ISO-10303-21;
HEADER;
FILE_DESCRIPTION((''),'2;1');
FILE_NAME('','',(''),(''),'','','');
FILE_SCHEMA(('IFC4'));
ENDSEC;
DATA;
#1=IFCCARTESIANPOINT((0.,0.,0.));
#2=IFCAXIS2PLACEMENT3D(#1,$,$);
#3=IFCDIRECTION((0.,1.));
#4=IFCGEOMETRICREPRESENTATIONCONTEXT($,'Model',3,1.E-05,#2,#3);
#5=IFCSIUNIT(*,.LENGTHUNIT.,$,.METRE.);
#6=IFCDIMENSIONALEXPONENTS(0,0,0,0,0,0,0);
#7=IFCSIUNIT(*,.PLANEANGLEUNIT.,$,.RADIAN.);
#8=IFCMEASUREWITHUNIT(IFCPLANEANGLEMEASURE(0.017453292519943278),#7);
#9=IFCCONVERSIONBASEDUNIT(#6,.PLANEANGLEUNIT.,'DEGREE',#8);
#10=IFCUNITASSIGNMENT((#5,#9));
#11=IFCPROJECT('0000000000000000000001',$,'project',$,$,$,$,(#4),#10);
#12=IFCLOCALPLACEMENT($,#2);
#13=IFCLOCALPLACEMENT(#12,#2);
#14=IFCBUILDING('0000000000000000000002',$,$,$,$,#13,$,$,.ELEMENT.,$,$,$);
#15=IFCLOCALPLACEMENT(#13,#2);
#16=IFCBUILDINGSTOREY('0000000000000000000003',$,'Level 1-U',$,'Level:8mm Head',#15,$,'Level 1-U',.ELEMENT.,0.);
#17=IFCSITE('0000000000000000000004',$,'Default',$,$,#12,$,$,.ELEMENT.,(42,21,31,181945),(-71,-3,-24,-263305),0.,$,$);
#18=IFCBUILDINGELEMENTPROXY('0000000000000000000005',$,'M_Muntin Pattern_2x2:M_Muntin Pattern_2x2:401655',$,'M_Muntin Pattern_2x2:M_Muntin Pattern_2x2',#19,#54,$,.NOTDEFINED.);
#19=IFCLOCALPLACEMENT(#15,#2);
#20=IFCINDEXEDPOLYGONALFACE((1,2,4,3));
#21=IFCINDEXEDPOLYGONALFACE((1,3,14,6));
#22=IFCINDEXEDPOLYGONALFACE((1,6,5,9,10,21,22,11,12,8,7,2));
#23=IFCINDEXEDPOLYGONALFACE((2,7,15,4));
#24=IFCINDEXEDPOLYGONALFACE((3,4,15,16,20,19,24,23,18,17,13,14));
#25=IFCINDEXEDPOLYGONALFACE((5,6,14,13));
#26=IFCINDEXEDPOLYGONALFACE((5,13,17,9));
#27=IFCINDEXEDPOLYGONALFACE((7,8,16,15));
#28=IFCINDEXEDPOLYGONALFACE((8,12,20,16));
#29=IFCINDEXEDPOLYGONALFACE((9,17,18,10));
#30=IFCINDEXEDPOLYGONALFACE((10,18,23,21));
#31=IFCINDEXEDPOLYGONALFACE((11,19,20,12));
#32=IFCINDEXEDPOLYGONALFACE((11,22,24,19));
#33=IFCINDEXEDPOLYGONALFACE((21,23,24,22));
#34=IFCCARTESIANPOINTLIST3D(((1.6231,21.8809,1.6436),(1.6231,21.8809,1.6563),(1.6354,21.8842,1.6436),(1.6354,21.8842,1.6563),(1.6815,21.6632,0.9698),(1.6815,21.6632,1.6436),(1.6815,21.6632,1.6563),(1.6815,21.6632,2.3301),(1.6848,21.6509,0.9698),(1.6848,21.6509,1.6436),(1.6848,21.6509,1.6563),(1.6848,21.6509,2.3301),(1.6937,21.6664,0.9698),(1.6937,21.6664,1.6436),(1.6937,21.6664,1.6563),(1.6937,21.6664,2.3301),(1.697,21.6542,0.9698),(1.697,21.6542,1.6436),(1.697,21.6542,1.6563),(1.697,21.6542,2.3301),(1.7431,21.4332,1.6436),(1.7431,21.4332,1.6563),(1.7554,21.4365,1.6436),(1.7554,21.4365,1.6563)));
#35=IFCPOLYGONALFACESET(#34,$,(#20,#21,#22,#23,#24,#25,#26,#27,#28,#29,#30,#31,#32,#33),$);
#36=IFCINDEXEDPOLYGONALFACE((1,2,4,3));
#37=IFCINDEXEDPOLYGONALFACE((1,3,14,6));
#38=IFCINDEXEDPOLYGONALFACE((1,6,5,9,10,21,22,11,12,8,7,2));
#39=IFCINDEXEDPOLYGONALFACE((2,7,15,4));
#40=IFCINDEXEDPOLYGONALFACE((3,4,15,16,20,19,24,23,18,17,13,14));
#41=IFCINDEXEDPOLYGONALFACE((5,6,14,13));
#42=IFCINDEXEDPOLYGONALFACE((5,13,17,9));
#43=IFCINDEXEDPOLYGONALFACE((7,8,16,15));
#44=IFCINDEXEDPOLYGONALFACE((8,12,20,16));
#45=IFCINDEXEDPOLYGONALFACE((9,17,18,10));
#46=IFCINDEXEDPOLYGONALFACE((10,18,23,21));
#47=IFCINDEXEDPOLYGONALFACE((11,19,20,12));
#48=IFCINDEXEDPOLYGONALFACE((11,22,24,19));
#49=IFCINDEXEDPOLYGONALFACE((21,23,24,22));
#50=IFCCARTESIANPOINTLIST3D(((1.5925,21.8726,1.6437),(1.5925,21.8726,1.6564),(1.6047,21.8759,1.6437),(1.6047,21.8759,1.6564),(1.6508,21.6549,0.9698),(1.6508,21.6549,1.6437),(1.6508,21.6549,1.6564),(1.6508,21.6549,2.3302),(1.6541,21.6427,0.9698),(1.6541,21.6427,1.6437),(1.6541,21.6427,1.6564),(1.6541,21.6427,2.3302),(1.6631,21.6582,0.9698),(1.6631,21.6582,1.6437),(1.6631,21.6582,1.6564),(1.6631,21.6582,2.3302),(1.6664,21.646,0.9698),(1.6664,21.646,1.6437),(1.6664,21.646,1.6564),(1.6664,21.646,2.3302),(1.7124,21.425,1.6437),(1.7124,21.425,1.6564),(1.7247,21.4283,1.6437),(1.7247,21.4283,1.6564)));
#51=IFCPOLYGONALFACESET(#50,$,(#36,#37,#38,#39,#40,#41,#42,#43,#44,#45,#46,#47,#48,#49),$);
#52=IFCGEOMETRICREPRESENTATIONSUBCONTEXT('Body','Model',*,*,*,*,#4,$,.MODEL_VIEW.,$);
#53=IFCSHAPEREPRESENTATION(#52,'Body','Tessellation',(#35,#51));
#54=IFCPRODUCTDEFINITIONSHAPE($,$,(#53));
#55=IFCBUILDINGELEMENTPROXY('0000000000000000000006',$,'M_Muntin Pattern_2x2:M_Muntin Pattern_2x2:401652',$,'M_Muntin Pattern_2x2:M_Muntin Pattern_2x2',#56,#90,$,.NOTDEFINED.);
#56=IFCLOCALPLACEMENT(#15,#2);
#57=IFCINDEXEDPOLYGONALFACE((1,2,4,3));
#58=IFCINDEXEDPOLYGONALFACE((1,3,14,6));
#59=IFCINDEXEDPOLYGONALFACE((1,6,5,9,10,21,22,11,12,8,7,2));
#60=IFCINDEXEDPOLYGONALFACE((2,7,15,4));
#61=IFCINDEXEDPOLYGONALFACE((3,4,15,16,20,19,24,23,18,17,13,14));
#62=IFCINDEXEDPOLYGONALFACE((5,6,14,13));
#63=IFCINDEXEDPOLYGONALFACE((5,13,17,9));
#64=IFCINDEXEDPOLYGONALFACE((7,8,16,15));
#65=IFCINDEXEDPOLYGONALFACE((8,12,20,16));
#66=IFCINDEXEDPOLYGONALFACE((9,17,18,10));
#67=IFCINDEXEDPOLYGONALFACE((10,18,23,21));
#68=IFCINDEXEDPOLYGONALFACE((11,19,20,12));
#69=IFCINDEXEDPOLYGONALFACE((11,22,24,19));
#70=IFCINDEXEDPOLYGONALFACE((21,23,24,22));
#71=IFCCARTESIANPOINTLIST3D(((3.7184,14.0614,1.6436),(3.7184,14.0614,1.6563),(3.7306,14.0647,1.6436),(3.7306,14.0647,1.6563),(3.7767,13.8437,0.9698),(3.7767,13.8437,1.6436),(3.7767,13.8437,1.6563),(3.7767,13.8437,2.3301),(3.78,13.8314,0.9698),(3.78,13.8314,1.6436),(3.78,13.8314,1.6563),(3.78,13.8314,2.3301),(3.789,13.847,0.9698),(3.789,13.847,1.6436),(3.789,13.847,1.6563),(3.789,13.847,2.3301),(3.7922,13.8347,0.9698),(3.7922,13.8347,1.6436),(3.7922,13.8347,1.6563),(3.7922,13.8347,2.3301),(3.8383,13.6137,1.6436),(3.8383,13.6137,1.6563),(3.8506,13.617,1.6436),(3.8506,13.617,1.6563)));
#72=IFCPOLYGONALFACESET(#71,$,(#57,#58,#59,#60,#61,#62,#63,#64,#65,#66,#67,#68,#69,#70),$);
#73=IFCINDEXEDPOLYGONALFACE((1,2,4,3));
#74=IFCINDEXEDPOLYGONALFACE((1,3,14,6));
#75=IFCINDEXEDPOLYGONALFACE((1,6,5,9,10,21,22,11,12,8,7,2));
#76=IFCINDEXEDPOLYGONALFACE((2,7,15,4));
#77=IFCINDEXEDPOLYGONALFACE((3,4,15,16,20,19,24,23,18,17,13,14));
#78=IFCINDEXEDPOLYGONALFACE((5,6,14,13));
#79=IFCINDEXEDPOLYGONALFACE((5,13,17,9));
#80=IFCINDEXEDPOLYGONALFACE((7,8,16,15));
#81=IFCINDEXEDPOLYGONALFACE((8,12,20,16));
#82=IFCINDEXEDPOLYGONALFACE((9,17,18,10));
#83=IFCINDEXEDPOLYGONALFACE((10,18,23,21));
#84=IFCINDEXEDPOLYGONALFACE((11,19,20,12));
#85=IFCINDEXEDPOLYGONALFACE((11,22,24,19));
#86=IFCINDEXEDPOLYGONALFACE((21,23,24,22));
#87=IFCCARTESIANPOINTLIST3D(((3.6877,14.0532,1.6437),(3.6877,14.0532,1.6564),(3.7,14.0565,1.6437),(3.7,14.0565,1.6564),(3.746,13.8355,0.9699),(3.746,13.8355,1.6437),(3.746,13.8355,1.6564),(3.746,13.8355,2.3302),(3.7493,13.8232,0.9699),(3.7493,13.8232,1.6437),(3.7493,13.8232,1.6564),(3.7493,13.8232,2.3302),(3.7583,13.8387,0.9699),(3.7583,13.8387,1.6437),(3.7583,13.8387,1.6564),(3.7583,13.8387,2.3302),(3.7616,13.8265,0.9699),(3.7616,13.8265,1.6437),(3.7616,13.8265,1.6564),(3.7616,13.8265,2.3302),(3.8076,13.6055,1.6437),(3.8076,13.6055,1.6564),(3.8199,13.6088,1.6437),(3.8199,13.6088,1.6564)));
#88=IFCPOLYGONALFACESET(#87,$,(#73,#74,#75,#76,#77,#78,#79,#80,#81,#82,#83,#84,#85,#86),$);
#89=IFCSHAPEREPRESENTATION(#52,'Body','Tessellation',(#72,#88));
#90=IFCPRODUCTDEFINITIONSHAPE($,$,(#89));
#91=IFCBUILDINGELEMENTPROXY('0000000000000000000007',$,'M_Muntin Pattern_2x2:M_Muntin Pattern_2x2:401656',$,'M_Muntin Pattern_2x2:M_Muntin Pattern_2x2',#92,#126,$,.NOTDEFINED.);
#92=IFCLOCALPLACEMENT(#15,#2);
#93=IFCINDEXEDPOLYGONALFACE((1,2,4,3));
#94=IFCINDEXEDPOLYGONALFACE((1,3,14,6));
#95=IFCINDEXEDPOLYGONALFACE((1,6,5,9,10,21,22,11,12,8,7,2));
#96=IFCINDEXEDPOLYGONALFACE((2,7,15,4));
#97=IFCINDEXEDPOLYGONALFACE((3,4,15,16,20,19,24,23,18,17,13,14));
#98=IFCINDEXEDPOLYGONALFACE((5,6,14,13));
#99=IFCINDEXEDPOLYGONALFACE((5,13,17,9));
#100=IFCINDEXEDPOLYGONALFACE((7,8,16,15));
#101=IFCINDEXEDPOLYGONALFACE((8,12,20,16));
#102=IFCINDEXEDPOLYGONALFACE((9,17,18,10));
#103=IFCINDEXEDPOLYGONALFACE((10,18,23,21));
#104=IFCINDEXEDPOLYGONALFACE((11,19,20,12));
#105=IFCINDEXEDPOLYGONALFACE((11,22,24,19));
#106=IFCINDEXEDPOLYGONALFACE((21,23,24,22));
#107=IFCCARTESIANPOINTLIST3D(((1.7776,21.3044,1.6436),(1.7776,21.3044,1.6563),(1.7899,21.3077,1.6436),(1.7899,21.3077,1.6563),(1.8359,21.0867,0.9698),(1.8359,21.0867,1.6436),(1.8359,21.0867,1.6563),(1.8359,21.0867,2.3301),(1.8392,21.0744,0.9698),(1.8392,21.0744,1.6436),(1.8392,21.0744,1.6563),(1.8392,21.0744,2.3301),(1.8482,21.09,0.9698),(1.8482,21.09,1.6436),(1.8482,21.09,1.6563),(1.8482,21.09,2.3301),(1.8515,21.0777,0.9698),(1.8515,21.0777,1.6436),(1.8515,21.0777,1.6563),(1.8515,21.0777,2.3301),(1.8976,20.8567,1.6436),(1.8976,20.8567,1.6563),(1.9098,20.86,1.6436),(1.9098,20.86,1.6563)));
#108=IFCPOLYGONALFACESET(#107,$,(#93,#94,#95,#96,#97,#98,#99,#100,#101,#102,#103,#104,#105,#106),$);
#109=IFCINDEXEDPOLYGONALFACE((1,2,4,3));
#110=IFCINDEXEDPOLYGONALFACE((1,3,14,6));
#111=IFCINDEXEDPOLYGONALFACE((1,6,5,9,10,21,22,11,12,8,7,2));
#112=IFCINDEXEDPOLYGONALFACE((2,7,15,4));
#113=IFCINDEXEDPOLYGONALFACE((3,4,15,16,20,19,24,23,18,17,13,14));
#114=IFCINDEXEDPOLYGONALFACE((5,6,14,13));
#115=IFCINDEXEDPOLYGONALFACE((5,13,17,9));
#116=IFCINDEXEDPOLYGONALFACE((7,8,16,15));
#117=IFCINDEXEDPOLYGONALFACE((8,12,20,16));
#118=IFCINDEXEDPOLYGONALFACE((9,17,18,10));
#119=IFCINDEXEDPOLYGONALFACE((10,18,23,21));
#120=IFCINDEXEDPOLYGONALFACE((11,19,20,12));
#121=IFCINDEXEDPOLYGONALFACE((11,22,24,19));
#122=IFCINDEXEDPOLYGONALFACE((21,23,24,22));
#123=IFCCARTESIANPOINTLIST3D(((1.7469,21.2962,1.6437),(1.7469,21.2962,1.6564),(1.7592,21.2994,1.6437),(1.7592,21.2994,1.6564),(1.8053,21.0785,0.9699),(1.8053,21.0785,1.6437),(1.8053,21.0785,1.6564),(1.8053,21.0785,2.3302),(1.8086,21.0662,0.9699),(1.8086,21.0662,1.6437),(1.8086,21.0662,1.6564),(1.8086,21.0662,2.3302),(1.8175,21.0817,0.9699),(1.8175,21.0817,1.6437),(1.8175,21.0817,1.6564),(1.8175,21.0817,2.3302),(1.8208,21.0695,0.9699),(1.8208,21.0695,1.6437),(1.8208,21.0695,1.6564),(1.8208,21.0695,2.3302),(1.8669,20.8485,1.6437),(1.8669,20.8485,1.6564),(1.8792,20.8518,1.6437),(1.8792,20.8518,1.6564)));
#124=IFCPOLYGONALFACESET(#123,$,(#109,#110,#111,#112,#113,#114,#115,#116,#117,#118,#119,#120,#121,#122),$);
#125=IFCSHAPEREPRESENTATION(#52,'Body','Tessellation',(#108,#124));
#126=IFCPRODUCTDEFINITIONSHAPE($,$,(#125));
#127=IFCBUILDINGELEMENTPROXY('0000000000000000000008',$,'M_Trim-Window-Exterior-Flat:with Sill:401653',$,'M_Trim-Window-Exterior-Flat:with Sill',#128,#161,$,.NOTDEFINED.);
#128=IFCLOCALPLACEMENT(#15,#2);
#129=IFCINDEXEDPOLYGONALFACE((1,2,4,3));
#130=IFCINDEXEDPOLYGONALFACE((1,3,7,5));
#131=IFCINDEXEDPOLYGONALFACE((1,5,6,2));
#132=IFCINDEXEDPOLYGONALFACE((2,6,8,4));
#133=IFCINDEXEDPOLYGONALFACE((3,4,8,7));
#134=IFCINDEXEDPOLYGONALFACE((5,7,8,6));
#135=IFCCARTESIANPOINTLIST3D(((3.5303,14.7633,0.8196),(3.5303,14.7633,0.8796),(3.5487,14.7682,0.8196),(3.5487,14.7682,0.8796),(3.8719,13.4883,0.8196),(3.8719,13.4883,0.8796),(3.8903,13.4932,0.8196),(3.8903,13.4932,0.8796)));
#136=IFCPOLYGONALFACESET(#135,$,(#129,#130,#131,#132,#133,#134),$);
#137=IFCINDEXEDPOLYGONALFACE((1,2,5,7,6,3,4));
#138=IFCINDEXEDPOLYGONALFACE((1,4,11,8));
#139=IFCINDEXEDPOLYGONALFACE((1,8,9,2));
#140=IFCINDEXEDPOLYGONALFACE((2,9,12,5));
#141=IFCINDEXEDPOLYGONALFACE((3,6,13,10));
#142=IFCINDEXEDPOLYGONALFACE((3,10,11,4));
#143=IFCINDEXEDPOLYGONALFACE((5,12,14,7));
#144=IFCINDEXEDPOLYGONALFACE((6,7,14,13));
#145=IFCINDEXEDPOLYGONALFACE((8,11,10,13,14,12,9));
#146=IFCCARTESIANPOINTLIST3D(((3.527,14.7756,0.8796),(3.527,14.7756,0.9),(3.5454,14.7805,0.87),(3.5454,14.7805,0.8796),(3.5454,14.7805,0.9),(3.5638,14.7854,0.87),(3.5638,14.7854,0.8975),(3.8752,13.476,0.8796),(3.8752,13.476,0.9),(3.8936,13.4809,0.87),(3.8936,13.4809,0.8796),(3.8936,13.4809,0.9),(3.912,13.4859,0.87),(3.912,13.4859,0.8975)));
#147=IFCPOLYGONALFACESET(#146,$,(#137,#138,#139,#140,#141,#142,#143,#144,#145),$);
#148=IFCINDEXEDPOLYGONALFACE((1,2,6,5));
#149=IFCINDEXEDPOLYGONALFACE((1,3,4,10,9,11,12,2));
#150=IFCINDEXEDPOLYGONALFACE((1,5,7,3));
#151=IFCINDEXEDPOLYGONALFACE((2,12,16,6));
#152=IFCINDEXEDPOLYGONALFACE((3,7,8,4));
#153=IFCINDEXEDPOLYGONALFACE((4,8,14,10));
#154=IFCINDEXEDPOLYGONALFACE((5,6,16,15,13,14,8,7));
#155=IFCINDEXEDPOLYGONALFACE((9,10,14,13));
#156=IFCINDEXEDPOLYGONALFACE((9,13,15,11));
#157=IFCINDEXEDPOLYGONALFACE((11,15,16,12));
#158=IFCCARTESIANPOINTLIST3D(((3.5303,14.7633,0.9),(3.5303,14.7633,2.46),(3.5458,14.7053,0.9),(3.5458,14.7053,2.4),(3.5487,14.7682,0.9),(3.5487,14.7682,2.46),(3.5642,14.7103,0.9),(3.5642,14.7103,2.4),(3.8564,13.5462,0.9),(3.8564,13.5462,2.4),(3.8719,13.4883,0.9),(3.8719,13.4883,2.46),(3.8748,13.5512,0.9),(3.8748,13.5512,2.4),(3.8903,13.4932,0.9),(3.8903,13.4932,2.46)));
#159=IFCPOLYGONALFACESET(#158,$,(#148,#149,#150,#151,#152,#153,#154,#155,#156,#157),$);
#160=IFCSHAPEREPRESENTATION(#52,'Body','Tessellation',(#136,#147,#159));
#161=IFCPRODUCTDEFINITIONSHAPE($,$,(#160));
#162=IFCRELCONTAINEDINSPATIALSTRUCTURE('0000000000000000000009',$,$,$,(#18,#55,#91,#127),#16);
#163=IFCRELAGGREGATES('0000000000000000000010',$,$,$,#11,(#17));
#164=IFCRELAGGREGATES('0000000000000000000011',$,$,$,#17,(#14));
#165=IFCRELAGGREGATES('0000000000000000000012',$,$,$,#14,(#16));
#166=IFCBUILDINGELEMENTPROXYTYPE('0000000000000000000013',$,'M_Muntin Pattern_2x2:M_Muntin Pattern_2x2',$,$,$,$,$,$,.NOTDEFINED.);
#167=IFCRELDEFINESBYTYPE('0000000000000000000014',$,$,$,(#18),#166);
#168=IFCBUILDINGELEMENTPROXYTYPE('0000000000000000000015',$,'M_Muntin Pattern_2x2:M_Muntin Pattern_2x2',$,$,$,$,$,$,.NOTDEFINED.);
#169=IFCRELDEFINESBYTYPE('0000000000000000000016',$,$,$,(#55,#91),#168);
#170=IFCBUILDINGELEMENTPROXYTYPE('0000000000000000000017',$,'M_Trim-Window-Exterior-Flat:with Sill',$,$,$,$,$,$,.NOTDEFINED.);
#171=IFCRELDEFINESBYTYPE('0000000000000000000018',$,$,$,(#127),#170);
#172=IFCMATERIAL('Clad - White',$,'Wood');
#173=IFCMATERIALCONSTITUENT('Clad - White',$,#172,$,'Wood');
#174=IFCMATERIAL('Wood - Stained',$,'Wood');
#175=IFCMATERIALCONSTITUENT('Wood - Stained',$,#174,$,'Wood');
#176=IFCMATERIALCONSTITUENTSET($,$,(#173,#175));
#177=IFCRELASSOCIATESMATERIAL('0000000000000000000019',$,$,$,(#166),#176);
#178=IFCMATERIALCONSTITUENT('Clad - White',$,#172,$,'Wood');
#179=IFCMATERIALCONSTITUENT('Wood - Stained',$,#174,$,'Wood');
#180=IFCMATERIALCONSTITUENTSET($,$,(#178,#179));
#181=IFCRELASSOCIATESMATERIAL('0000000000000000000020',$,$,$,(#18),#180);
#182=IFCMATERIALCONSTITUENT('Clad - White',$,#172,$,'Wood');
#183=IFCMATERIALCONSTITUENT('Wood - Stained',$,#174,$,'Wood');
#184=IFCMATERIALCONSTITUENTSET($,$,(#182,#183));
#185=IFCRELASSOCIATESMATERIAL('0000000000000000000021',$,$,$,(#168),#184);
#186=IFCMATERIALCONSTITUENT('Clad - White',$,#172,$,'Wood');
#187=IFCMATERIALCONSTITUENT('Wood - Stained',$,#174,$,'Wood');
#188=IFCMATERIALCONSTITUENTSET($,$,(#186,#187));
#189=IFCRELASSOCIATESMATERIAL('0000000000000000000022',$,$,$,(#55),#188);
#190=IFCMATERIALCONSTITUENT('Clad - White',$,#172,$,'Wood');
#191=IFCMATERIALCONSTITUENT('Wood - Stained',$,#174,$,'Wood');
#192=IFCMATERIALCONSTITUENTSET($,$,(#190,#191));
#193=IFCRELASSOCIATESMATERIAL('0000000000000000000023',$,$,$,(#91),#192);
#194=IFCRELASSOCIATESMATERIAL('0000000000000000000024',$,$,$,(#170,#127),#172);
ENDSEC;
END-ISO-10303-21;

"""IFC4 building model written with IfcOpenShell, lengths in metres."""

from ifc_helpers import new_model, entity, si_unit, converted_unit, direction, frame, origin, place, context, subcontext, project, spatial, indexed_curve, outline, extrude, source, transform, mapped, material, constituent, constituent_set, type_object, type_shapes, element, save


model = new_model("IFC4")

# Units and contexts
model_context = context("Model", 3, precision=1e-05, world=origin(), true_north=direction((0.0, 1.0)))
body_context = subcontext(model_context, "Body", "Model", "MODEL_VIEW")
ifc_project = project(units=[si_unit("LENGTHUNIT", "METRE"), converted_unit("PLANEANGLEUNIT", "DEGREE", entity("IfcPlaneAngleMeasure", 0.017453292519943278), si_unit("PLANEANGLEUNIT", "RADIAN"), dimensions=[0, 0, 0, 0, 0, 0, 0])], contexts=[model_context])

# Site, building, storey
site_placement = place(None, origin())
site = spatial("IfcSite", under=ifc_project, at=site_placement, Name="Default", CompositionType="ELEMENT", RefLatitude=(42, 21, 31, 181945), RefLongitude=(-71, -3, -24, -263305), RefElevation=0.0)
building_placement = place(site_placement, origin())
building = spatial("IfcBuilding", under=site, at=building_placement, CompositionType="ELEMENT")
storey_placement = place(building_placement, origin())
storey = spatial("IfcBuildingStorey", under=building, at=storey_placement, Name="Level 1-U", ObjectType="Level:8mm Head", LongName="Level 1-U", CompositionType="ELEMENT", Elevation=0.0)

# Building element proxies
ifc_material_1 = material(Name="Clad - White", Category="Wood")
ifc_material_2 = material(Name="Wood - Stained", Category="Wood")
ifc_constituent_1 = constituent(ifc_material_1, Name="Clad - White", Category="Wood")
ifc_constituent_2 = constituent(ifc_material_2, Name="Wood - Stained", Category="Wood")
ifc_constituent_set_1 = constituent_set(constituents=[ifc_constituent_1, ifc_constituent_2])
building_element_proxy_type_1 = type_object("IfcBuildingElementProxyType", Name="M_Muntin Pattern_2x2:M_Muntin Pattern_2x2", PredefinedType="NOTDEFINED", material=ifc_constituent_set_1)
shared_shape_1 = source(origin(), body_context, "Body", "SweptSolid", [
    extrude(outline(indexed_curve([(0.0064, -0.0064), (0.6801, -0.0064), (0.6801, 0.0063), (0.0064, 0.0063), (0.0064, 0.2317), (-0.0063, 0.2317), (-0.0063, 0.0063), (-0.6802, 0.0063), (-0.6802, -0.0064), (-0.0063, -0.0064), (-0.0063, -0.2317), (0.0064, -0.2317), (0.0064, -0.0064)], self_intersect=False)), frame((0.0, 0.0095, 0.6801), z_axis=(0.0, 1.0, 0.0), x_axis=(0.0, 0.0, 1.0)), (0.0, 0.0, 1.0), 0.0127),
    extrude(outline(indexed_curve([(0.0064, -0.0064), (0.6802, -0.0064), (0.6802, 0.0063), (0.0064, 0.0063), (0.0064, 0.2317), (-0.0063, 0.2317), (-0.0063, 0.0063), (-0.6802, 0.0063), (-0.6802, -0.0064), (-0.0063, -0.0064), (-0.0063, -0.2317), (0.0064, -0.2317), (0.0064, -0.0064)], self_intersect=False)), frame((0.0, -0.0222, 0.6802), z_axis=(0.0, 1.0, 0.0), x_axis=(0.0, 0.0, 1.0)), (0.0, 0.0, 1.0), 0.0127),
])
type_shapes(building_element_proxy_type_1, [shared_shape_1])
ifc_constituent_3 = constituent(ifc_material_1, Name="Clad - White", Category="Wood")
ifc_constituent_4 = constituent(ifc_material_2, Name="Wood - Stained", Category="Wood")
ifc_constituent_set_2 = constituent_set(constituents=[ifc_constituent_3, ifc_constituent_4])
proxy_1_placement = place(storey_placement, frame((1.6739, 21.6546, 0.9698), z_axis=(0.0, 0.0, 1.0), x_axis=(0.258819, -0.965926, 0.0)))
element("IfcBuildingElementProxy", 1, at=proxy_1_placement, inside=storey, type_object=building_element_proxy_type_1, material=ifc_constituent_set_2, Name="M_Muntin Pattern_2x2:M_Muntin Pattern_2x2:401655", ObjectType="M_Muntin Pattern_2x2:M_Muntin Pattern_2x2", PredefinedType="NOTDEFINED", context=body_context, shape_type="MappedRepresentation", body=[
    mapped(shared_shape_1, transform((0.0, 0.0, 0.0), scale=1.0)),
])
ifc_constituent_5 = constituent(ifc_material_1, Name="Clad - White", Category="Wood")
ifc_constituent_6 = constituent(ifc_material_2, Name="Wood - Stained", Category="Wood")
ifc_constituent_set_3 = constituent_set(constituents=[ifc_constituent_5, ifc_constituent_6])
ifc_constituent_7 = constituent(ifc_material_1, Name="Clad - White", Category="Wood")
ifc_constituent_8 = constituent(ifc_material_2, Name="Wood - Stained", Category="Wood")
ifc_constituent_set_4 = constituent_set(constituents=[ifc_constituent_7, ifc_constituent_8])
building_element_proxy_type_2 = type_object("IfcBuildingElementProxyType", Name="M_Muntin Pattern_2x2:M_Muntin Pattern_2x2", PredefinedType="NOTDEFINED", material=ifc_constituent_set_4)
shared_shape_2 = source(origin(), body_context, "Body", "SweptSolid", [
    extrude(outline(indexed_curve([(0.0064, -0.0064), (0.6801, -0.0064), (0.6801, 0.0063), (0.0064, 0.0063), (0.0064, 0.2317), (-0.0063, 0.2317), (-0.0063, 0.0063), (-0.6802, 0.0063), (-0.6802, -0.0064), (-0.0063, -0.0064), (-0.0063, -0.2317), (0.0064, -0.2317), (0.0064, -0.0064)], self_intersect=False)), frame((0.0, -0.0222, 0.6801), z_axis=(0.0, 1.0, 0.0), x_axis=(0.0, 0.0, 1.0)), (0.0, 0.0, 1.0), 0.0127),
    extrude(outline(indexed_curve([(0.0064, -0.0064), (0.6802, -0.0064), (0.6802, 0.0063), (0.0064, 0.0063), (0.0064, 0.2317), (-0.0063, 0.2317), (-0.0063, 0.0063), (-0.6802, 0.0063), (-0.6802, -0.0064), (-0.0063, -0.0064), (-0.0063, -0.2317), (0.0064, -0.2317), (0.0064, -0.0064)], self_intersect=False)), frame((0.0, 0.0095, 0.6802), z_axis=(0.0, 1.0, 0.0), x_axis=(0.0, 0.0, 1.0)), (0.0, 0.0, 1.0), 0.0127),
])
type_shapes(building_element_proxy_type_2, [shared_shape_2])
proxy_2_placement = place(storey_placement, frame((3.7691, 13.8351, 0.9699), z_axis=(0.0, 0.0, 1.0), x_axis=(-0.258819, 0.965926, 0.0)))
element("IfcBuildingElementProxy", 2, at=proxy_2_placement, inside=storey, type_object=building_element_proxy_type_2, material=ifc_constituent_set_3, Name="M_Muntin Pattern_2x2:M_Muntin Pattern_2x2:401652", ObjectType="M_Muntin Pattern_2x2:M_Muntin Pattern_2x2", PredefinedType="NOTDEFINED", context=body_context, shape_type="MappedRepresentation", body=[
    mapped(shared_shape_2, transform((0.0, 0.0, 0.0), scale=1.0)),
])
ifc_constituent_9 = constituent(ifc_material_1, Name="Clad - White", Category="Wood")
ifc_constituent_10 = constituent(ifc_material_2, Name="Wood - Stained", Category="Wood")
ifc_constituent_set_5 = constituent_set(constituents=[ifc_constituent_9, ifc_constituent_10])
proxy_3_placement = place(storey_placement, frame((1.8284, 21.0781, 0.9699), z_axis=(0.0, 0.0, 1.0), x_axis=(-0.258819, 0.965926, 0.0)))
element("IfcBuildingElementProxy", 3, at=proxy_3_placement, inside=storey, type_object=building_element_proxy_type_2, material=ifc_constituent_set_5, Name="M_Muntin Pattern_2x2:M_Muntin Pattern_2x2:401656", ObjectType="M_Muntin Pattern_2x2:M_Muntin Pattern_2x2", PredefinedType="NOTDEFINED", context=body_context, shape_type="MappedRepresentation", body=[
    mapped(shared_shape_2, transform((0.0, 0.0, 0.0), scale=1.0)),
])
building_element_proxy_type_3 = type_object("IfcBuildingElementProxyType", Name="M_Trim-Window-Exterior-Flat:with Sill", PredefinedType="NOTDEFINED", material=ifc_material_1)
shared_shape_3 = source(origin(), body_context, "Body", "SweptSolid", [
    extrude(outline(indexed_curve([(-0.66, -0.03), (0.66, -0.03), (0.66, 0.03), (-0.66, 0.03), (-0.66, -0.03)], self_intersect=False)), frame((0.0, -1.5504, 0.0), z_axis=(0.0, 0.0, 1.0), x_axis=(-1.0, 0.0, 0.0)), (0.0, 0.0, 1.0), 0.019),
    extrude(outline(indexed_curve([(-0.019, -0.0152), (0.0, -0.0152), (0.0, -0.0057), (0.019, -0.0057), (0.019, 0.0148), (0.0, 0.0148), (-0.019, 0.0123), (-0.019, -0.0152)], self_intersect=False)), frame((-0.6727, -1.5148, 0.019), z_axis=(1.0, 0.0, 0.0), x_axis=(0.0, 0.0, -1.0)), (0.0, 0.0, 1.0), 1.3454),
    extrude(outline(indexed_curve([(-0.795, -0.66), (0.765, -0.66), (0.765, -0.6), (-0.735, -0.6), (-0.735, 0.6), (0.765, 0.6), (0.765, 0.66), (-0.795, 0.66), (-0.795, -0.66)], self_intersect=False)), frame((0.0, -0.735, 0.0), z_axis=(0.0, 0.0, 1.0), x_axis=(0.0, -1.0, 0.0)), (0.0, 0.0, 1.0), 0.019),
])
type_shapes(building_element_proxy_type_3, [shared_shape_3])
for number, where, z_axis, x_axis, name in (
    (4, (3.7011, 14.1258, 2.4), (0.965926, 0.258819, 0.0), (-0.258819, 0.965926, 0.0), "M_Trim-Window-Exterior-Flat:with Sill:401653"),
):
    element("IfcBuildingElementProxy", number, at=place(storey_placement, frame(where, z_axis=z_axis, x_axis=x_axis)), inside=storey, type_object=building_element_proxy_type_3, material=ifc_material_1, Name=name, ObjectType="M_Trim-Window-Exterior-Flat:with Sill", PredefinedType="NOTDEFINED", context=body_context, shape_type="MappedRepresentation", body=[
        mapped(shared_shape_3, transform((0.0, 0.0, 0.0), scale=1.0)),
    ])

save(model, "model.ifc")
